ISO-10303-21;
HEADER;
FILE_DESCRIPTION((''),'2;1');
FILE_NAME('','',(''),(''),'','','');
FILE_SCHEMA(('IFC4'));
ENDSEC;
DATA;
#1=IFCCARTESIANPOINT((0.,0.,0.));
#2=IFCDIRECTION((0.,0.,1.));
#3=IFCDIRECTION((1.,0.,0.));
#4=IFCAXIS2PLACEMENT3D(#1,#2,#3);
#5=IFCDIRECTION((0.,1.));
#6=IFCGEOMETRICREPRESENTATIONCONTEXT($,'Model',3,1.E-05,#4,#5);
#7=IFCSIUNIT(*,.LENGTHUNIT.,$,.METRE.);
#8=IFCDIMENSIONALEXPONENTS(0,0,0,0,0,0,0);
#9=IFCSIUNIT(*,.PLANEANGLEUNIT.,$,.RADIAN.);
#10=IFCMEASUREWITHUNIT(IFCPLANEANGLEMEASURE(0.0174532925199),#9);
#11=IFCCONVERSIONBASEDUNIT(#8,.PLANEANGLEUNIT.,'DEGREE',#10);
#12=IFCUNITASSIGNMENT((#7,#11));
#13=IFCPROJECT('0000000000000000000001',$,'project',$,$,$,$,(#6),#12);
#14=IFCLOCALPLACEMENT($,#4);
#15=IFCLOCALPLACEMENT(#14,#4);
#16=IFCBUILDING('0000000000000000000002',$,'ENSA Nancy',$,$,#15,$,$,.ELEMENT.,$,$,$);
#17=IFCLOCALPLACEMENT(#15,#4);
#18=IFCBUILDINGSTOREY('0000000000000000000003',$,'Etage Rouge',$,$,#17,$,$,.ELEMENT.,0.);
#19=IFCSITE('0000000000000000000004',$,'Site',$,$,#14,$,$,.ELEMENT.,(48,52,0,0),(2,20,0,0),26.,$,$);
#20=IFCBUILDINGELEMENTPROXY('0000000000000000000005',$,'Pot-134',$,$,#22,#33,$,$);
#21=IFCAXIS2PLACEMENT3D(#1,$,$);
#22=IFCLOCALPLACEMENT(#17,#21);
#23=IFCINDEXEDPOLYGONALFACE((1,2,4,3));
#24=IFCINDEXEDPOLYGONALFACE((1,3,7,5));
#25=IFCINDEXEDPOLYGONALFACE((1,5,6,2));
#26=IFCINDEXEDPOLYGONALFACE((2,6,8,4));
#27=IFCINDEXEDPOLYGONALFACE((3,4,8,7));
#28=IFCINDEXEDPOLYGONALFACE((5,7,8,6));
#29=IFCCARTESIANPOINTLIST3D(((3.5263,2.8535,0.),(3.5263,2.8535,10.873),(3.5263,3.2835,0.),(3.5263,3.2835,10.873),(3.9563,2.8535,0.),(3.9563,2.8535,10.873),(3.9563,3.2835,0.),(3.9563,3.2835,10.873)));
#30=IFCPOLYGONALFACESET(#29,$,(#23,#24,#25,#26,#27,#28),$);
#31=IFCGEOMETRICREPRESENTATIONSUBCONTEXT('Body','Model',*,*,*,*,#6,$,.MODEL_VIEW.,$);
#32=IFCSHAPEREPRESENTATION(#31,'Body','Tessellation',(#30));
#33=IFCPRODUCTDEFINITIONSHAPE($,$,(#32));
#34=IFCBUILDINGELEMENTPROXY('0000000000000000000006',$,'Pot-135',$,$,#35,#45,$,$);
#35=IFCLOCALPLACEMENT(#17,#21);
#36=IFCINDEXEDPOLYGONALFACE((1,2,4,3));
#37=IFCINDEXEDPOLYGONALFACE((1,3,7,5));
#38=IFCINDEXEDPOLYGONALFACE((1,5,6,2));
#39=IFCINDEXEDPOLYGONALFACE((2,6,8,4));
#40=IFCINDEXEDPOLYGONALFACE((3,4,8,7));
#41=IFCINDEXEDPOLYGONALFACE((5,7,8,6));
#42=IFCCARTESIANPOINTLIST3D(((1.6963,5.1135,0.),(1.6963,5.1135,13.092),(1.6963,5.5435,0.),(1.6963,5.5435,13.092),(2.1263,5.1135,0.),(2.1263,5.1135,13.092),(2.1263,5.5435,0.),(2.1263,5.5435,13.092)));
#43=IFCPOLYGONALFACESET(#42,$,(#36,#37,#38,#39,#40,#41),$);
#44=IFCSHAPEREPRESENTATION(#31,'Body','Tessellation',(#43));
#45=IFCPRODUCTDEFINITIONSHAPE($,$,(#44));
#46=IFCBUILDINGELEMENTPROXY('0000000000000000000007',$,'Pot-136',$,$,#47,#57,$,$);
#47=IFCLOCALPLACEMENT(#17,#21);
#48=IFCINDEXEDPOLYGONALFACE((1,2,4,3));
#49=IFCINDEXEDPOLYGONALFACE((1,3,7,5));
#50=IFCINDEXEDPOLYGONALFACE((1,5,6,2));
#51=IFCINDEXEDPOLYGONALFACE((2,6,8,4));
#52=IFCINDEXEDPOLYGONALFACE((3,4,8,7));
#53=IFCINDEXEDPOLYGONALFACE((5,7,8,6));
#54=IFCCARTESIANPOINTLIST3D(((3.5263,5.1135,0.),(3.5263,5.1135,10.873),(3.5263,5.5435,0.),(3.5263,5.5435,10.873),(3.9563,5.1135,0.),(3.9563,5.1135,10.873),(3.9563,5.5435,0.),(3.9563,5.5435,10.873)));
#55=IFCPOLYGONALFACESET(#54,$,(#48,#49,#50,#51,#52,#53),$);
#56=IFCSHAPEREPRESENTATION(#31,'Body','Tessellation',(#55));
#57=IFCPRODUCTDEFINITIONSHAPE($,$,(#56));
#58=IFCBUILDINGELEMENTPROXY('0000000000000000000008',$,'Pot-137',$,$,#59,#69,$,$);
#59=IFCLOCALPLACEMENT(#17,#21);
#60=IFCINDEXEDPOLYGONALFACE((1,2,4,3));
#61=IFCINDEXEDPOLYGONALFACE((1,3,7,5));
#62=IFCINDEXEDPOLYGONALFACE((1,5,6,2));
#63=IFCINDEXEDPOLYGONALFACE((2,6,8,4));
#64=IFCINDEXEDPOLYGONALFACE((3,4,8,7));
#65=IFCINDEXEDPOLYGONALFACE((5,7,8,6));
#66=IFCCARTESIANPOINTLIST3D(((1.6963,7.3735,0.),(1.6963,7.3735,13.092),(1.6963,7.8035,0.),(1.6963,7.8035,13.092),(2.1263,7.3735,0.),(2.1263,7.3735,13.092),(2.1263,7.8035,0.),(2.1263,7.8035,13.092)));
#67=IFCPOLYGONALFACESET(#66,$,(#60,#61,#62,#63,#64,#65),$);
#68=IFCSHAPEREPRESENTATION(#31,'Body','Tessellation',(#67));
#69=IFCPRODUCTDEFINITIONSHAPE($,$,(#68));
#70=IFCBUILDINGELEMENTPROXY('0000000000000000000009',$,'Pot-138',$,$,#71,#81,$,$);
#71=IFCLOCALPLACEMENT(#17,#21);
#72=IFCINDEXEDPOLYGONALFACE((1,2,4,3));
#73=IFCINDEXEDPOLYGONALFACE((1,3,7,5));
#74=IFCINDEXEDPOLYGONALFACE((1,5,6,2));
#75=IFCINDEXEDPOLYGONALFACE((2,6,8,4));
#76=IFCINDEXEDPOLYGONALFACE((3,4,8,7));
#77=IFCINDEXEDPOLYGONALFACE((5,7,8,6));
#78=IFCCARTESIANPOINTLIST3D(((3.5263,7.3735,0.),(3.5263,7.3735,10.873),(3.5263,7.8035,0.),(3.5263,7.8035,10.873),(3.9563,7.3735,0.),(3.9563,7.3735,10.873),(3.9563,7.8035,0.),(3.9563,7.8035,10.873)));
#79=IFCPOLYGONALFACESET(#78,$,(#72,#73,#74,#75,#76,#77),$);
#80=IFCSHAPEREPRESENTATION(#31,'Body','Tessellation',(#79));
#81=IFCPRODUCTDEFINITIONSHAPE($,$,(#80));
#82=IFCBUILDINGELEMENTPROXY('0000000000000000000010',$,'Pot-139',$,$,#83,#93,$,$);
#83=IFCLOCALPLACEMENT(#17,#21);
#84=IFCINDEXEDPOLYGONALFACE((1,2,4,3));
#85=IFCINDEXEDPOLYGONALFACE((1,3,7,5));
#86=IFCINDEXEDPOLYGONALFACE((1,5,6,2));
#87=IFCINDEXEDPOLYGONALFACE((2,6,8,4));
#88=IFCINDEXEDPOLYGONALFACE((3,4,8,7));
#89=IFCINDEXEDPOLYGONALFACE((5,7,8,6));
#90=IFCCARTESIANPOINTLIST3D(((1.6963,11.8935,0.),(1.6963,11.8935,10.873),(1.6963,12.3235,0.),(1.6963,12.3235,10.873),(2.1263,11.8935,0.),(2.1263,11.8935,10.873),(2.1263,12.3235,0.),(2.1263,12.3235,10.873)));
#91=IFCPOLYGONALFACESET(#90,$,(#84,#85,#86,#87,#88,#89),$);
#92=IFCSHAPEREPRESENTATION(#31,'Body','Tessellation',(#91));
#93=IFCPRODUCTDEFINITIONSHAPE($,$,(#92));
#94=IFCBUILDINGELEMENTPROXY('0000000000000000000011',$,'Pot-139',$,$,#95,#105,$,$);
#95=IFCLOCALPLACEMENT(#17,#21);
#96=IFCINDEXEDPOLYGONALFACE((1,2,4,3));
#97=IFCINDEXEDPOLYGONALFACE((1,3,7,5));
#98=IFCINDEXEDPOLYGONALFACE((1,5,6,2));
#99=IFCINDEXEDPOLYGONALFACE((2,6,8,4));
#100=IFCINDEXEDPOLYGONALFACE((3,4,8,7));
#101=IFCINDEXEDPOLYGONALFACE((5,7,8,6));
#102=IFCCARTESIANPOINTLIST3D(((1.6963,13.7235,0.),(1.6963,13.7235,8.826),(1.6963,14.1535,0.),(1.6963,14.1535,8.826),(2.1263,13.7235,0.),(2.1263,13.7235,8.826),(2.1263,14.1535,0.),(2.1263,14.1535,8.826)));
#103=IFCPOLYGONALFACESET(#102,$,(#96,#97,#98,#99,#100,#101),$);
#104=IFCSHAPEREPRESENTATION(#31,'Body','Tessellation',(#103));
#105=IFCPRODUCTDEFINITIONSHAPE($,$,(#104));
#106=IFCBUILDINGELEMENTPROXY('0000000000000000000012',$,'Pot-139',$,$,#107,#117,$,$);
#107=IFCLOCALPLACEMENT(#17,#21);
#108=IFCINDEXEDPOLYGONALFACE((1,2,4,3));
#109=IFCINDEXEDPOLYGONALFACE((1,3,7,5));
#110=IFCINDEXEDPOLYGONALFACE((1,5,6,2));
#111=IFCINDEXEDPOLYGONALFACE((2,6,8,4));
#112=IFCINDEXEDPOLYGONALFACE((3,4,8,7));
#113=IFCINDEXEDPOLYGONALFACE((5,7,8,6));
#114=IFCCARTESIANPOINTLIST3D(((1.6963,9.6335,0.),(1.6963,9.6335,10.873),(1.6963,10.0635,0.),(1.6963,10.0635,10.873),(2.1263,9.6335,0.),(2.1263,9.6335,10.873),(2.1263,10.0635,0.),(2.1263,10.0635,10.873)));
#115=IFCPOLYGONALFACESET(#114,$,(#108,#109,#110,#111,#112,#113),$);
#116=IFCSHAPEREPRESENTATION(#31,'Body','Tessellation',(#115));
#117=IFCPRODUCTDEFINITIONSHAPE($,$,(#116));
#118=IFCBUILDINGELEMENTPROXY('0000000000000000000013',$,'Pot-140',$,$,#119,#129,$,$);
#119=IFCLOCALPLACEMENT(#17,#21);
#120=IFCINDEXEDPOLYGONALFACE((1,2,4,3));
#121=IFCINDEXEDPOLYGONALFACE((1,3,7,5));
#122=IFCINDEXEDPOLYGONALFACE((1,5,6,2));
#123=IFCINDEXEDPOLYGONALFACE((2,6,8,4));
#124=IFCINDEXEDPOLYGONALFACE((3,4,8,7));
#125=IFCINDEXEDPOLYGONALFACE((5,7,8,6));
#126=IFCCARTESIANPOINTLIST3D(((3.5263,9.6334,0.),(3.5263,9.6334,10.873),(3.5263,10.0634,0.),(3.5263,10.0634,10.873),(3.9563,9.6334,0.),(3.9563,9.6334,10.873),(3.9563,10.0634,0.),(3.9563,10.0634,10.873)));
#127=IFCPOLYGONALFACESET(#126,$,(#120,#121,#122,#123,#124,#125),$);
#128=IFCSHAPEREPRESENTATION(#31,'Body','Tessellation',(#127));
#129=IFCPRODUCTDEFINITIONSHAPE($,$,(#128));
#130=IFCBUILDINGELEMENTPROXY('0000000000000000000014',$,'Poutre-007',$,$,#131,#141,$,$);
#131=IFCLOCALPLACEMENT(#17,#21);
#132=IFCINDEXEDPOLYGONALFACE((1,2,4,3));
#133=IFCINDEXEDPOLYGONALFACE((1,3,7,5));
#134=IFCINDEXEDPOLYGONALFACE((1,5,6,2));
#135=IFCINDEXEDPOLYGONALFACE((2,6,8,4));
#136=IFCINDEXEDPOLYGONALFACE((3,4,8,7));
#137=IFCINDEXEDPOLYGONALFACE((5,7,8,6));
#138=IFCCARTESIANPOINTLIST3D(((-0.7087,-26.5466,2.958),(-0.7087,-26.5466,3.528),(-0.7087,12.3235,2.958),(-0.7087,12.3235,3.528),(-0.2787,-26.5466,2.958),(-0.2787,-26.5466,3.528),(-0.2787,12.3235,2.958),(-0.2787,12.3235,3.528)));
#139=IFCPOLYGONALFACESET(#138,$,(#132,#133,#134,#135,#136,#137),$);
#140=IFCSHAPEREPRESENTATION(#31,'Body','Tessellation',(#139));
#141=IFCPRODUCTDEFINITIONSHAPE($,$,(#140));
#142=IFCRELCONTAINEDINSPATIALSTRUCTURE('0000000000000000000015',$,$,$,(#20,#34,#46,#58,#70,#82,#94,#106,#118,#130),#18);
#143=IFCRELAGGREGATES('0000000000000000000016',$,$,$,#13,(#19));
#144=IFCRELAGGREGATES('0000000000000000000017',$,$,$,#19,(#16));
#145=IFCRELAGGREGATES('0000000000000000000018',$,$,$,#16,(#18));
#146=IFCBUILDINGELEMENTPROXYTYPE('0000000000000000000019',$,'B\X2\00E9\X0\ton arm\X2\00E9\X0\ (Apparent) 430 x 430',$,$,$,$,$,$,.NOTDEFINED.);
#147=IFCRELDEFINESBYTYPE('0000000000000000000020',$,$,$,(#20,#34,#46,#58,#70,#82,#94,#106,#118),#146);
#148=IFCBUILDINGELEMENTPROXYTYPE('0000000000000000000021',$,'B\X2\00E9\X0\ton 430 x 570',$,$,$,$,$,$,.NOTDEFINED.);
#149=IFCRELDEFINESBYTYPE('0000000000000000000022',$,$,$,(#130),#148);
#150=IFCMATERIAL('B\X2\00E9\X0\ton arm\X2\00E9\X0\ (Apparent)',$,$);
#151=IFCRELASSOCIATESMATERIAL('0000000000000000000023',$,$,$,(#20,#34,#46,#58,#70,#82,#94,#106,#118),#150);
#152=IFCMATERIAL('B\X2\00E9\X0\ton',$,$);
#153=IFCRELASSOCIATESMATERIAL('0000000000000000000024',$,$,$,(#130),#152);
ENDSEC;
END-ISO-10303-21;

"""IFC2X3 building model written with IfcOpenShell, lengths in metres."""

from ifc_helpers import new_model, entity, si_unit, converted_unit, direction, frame, frame_2d, origin_with_axes, origin_2d_with_axis, place, context, subcontext, project, spatial, rectangle, extrude, material, type_object, element, save


model = new_model("IFC2X3")

# Units and contexts
model_context = context("Model", 3, precision=1e-05, world=origin_with_axes(), true_north=direction((0.0, 1.0)))
body_context = subcontext(model_context, "Body", "Model", "MODEL_VIEW")
ifc_project = project(units=[si_unit("LENGTHUNIT", "METRE"), converted_unit("PLANEANGLEUNIT", "DEGREE", entity("IfcPlaneAngleMeasure", 0.0174532925199), si_unit("PLANEANGLEUNIT", "RADIAN"), dimensions=[0, 0, 0, 0, 0, 0, 0])], contexts=[model_context])

# Site, building, storey
site_placement = place(None, origin_with_axes())
site = spatial("IfcSite", under=ifc_project, at=site_placement, Name="Site", CompositionType="ELEMENT", RefLatitude=(48, 52, 0, 0), RefLongitude=(2, 20, 0, 0), RefElevation=26.0)
building_placement = place(site_placement, origin_with_axes())
building = spatial("IfcBuilding", under=site, at=building_placement, Name="ENSA Nancy", CompositionType="ELEMENT")
storey_placement = place(building_placement, origin_with_axes())
storey = spatial("IfcBuildingStorey", under=building, at=storey_placement, Name="Etage Rouge", CompositionType="ELEMENT", Elevation=0.0)

# Building element proxies
ifc_material_1 = material(Name="Béton armé (Apparent)")
building_element_proxy_type_1 = type_object("IfcBuildingElementProxyType", Name="Béton armé (Apparent) 430 x 430", PredefinedType="NOTDEFINED")
proxy_1_placement = place(storey_placement, frame((3.7413, 3.0685, 0.0), z_axis=(0.0, 0.0, 1.0), x_axis=(1.0, 0.0, 0.0)))
element("IfcBuildingElementProxy", 1, at=proxy_1_placement, inside=storey, type_object=building_element_proxy_type_1, material=ifc_material_1, Name="Pot-134", context=body_context, shape_type="SweptSolid", body=[
    extrude(rectangle(XDim=0.43, YDim=0.43, at=origin_2d_with_axis()), origin_with_axes(), (0.0, 0.0, 1.0), 10.873),
])
proxy_2_placement = place(storey_placement, frame((1.9113, 5.3285, 0.0), z_axis=(0.0, 0.0, 1.0), x_axis=(1.0, 0.0, 0.0)))
element("IfcBuildingElementProxy", 2, at=proxy_2_placement, inside=storey, type_object=building_element_proxy_type_1, material=ifc_material_1, Name="Pot-135", context=body_context, shape_type="SweptSolid", body=[
    extrude(rectangle(XDim=0.43, YDim=0.43, at=origin_2d_with_axis()), origin_with_axes(), (0.0, 0.0, 1.0), 13.092),
])
proxy_3_placement = place(storey_placement, frame((3.7413, 5.3285, 0.0), z_axis=(0.0, 0.0, 1.0), x_axis=(1.0, 0.0, 0.0)))
element("IfcBuildingElementProxy", 3, at=proxy_3_placement, inside=storey, type_object=building_element_proxy_type_1, material=ifc_material_1, Name="Pot-136", context=body_context, shape_type="SweptSolid", body=[
    extrude(rectangle(XDim=0.43, YDim=0.43, at=origin_2d_with_axis()), origin_with_axes(), (0.0, 0.0, 1.0), 10.873),
])
proxy_4_placement = place(storey_placement, frame((1.9113, 7.5885, 0.0), z_axis=(0.0, 0.0, 1.0), x_axis=(1.0, 0.0, 0.0)))
element("IfcBuildingElementProxy", 4, at=proxy_4_placement, inside=storey, type_object=building_element_proxy_type_1, material=ifc_material_1, Name="Pot-137", context=body_context, shape_type="SweptSolid", body=[
    extrude(rectangle(XDim=0.43, YDim=0.43, at=origin_2d_with_axis()), origin_with_axes(), (0.0, 0.0, 1.0), 13.092),
])
for number, where, z_axis, x_axis, name in (
    (5, (3.7413, 7.5885, 0.0), (0.0, 0.0, 1.0), (1.0, 0.0, 0.0), "Pot-138"),
    (6, (1.9113, 12.1085, 0.0), (0.0, 0.0, 1.0), (1.0, 0.0, 0.0), "Pot-139"),
):
    element("IfcBuildingElementProxy", number, at=place(storey_placement, frame(where, z_axis=z_axis, x_axis=x_axis)), inside=storey, type_object=building_element_proxy_type_1, material=ifc_material_1, Name=name, context=body_context, shape_type="SweptSolid", body=[
        extrude(rectangle(XDim=0.43, YDim=0.43, at=origin_2d_with_axis()), origin_with_axes(), (0.0, 0.0, 1.0), 10.873),
    ])
proxy_5_placement = place(storey_placement, frame((1.9113, 13.9385, 0.0), z_axis=(0.0, 0.0, 1.0), x_axis=(1.0, 0.0, 0.0)))
element("IfcBuildingElementProxy", 7, at=proxy_5_placement, inside=storey, type_object=building_element_proxy_type_1, material=ifc_material_1, Name="Pot-139", context=body_context, shape_type="SweptSolid", body=[
    extrude(rectangle(XDim=0.43, YDim=0.43, at=origin_2d_with_axis()), origin_with_axes(), (0.0, 0.0, 1.0), 8.826),
])
for number, where, z_axis, x_axis, name in (
    (8, (1.9113, 9.8485, 0.0), (0.0, 0.0, 1.0), (1.0, 0.0, 0.0), "Pot-139"),
    (9, (3.7413, 9.8484, 0.0), (0.0, 0.0, 1.0), (1.0, 0.0, 0.0), "Pot-140"),
):
    element("IfcBuildingElementProxy", number, at=place(storey_placement, frame(where, z_axis=z_axis, x_axis=x_axis)), inside=storey, type_object=building_element_proxy_type_1, material=ifc_material_1, Name=name, context=body_context, shape_type="SweptSolid", body=[
        extrude(rectangle(XDim=0.43, YDim=0.43, at=origin_2d_with_axis()), origin_with_axes(), (0.0, 0.0, 1.0), 10.873),
    ])
ifc_material_2 = material(Name="Béton")
building_element_proxy_type_2 = type_object("IfcBuildingElementProxyType", Name="Béton 430 x 570", PredefinedType="NOTDEFINED")
proxy_6_placement = place(storey_placement, frame((-0.4937, 12.3235, 3.528), z_axis=(0.0, 0.0, 1.0), x_axis=(-1.0, 0.0, 0.0)))
element("IfcBuildingElementProxy", 10, at=proxy_6_placement, inside=storey, type_object=building_element_proxy_type_2, material=ifc_material_2, Name="Poutre-007", context=body_context, shape_type="SweptSolid", body=[
    extrude(rectangle(XDim=0.57, YDim=0.43, at=frame_2d((-0.285, 0.0), x_axis=(1.0, 0.0))), frame((0.0, 0.0, 0.0), z_axis=(0.0, 1.0, 0.0), x_axis=(0.0, 0.0, 1.0)), (0.0, 0.0, 1.0), 38.87),
])

save(model, "model.ifc")
